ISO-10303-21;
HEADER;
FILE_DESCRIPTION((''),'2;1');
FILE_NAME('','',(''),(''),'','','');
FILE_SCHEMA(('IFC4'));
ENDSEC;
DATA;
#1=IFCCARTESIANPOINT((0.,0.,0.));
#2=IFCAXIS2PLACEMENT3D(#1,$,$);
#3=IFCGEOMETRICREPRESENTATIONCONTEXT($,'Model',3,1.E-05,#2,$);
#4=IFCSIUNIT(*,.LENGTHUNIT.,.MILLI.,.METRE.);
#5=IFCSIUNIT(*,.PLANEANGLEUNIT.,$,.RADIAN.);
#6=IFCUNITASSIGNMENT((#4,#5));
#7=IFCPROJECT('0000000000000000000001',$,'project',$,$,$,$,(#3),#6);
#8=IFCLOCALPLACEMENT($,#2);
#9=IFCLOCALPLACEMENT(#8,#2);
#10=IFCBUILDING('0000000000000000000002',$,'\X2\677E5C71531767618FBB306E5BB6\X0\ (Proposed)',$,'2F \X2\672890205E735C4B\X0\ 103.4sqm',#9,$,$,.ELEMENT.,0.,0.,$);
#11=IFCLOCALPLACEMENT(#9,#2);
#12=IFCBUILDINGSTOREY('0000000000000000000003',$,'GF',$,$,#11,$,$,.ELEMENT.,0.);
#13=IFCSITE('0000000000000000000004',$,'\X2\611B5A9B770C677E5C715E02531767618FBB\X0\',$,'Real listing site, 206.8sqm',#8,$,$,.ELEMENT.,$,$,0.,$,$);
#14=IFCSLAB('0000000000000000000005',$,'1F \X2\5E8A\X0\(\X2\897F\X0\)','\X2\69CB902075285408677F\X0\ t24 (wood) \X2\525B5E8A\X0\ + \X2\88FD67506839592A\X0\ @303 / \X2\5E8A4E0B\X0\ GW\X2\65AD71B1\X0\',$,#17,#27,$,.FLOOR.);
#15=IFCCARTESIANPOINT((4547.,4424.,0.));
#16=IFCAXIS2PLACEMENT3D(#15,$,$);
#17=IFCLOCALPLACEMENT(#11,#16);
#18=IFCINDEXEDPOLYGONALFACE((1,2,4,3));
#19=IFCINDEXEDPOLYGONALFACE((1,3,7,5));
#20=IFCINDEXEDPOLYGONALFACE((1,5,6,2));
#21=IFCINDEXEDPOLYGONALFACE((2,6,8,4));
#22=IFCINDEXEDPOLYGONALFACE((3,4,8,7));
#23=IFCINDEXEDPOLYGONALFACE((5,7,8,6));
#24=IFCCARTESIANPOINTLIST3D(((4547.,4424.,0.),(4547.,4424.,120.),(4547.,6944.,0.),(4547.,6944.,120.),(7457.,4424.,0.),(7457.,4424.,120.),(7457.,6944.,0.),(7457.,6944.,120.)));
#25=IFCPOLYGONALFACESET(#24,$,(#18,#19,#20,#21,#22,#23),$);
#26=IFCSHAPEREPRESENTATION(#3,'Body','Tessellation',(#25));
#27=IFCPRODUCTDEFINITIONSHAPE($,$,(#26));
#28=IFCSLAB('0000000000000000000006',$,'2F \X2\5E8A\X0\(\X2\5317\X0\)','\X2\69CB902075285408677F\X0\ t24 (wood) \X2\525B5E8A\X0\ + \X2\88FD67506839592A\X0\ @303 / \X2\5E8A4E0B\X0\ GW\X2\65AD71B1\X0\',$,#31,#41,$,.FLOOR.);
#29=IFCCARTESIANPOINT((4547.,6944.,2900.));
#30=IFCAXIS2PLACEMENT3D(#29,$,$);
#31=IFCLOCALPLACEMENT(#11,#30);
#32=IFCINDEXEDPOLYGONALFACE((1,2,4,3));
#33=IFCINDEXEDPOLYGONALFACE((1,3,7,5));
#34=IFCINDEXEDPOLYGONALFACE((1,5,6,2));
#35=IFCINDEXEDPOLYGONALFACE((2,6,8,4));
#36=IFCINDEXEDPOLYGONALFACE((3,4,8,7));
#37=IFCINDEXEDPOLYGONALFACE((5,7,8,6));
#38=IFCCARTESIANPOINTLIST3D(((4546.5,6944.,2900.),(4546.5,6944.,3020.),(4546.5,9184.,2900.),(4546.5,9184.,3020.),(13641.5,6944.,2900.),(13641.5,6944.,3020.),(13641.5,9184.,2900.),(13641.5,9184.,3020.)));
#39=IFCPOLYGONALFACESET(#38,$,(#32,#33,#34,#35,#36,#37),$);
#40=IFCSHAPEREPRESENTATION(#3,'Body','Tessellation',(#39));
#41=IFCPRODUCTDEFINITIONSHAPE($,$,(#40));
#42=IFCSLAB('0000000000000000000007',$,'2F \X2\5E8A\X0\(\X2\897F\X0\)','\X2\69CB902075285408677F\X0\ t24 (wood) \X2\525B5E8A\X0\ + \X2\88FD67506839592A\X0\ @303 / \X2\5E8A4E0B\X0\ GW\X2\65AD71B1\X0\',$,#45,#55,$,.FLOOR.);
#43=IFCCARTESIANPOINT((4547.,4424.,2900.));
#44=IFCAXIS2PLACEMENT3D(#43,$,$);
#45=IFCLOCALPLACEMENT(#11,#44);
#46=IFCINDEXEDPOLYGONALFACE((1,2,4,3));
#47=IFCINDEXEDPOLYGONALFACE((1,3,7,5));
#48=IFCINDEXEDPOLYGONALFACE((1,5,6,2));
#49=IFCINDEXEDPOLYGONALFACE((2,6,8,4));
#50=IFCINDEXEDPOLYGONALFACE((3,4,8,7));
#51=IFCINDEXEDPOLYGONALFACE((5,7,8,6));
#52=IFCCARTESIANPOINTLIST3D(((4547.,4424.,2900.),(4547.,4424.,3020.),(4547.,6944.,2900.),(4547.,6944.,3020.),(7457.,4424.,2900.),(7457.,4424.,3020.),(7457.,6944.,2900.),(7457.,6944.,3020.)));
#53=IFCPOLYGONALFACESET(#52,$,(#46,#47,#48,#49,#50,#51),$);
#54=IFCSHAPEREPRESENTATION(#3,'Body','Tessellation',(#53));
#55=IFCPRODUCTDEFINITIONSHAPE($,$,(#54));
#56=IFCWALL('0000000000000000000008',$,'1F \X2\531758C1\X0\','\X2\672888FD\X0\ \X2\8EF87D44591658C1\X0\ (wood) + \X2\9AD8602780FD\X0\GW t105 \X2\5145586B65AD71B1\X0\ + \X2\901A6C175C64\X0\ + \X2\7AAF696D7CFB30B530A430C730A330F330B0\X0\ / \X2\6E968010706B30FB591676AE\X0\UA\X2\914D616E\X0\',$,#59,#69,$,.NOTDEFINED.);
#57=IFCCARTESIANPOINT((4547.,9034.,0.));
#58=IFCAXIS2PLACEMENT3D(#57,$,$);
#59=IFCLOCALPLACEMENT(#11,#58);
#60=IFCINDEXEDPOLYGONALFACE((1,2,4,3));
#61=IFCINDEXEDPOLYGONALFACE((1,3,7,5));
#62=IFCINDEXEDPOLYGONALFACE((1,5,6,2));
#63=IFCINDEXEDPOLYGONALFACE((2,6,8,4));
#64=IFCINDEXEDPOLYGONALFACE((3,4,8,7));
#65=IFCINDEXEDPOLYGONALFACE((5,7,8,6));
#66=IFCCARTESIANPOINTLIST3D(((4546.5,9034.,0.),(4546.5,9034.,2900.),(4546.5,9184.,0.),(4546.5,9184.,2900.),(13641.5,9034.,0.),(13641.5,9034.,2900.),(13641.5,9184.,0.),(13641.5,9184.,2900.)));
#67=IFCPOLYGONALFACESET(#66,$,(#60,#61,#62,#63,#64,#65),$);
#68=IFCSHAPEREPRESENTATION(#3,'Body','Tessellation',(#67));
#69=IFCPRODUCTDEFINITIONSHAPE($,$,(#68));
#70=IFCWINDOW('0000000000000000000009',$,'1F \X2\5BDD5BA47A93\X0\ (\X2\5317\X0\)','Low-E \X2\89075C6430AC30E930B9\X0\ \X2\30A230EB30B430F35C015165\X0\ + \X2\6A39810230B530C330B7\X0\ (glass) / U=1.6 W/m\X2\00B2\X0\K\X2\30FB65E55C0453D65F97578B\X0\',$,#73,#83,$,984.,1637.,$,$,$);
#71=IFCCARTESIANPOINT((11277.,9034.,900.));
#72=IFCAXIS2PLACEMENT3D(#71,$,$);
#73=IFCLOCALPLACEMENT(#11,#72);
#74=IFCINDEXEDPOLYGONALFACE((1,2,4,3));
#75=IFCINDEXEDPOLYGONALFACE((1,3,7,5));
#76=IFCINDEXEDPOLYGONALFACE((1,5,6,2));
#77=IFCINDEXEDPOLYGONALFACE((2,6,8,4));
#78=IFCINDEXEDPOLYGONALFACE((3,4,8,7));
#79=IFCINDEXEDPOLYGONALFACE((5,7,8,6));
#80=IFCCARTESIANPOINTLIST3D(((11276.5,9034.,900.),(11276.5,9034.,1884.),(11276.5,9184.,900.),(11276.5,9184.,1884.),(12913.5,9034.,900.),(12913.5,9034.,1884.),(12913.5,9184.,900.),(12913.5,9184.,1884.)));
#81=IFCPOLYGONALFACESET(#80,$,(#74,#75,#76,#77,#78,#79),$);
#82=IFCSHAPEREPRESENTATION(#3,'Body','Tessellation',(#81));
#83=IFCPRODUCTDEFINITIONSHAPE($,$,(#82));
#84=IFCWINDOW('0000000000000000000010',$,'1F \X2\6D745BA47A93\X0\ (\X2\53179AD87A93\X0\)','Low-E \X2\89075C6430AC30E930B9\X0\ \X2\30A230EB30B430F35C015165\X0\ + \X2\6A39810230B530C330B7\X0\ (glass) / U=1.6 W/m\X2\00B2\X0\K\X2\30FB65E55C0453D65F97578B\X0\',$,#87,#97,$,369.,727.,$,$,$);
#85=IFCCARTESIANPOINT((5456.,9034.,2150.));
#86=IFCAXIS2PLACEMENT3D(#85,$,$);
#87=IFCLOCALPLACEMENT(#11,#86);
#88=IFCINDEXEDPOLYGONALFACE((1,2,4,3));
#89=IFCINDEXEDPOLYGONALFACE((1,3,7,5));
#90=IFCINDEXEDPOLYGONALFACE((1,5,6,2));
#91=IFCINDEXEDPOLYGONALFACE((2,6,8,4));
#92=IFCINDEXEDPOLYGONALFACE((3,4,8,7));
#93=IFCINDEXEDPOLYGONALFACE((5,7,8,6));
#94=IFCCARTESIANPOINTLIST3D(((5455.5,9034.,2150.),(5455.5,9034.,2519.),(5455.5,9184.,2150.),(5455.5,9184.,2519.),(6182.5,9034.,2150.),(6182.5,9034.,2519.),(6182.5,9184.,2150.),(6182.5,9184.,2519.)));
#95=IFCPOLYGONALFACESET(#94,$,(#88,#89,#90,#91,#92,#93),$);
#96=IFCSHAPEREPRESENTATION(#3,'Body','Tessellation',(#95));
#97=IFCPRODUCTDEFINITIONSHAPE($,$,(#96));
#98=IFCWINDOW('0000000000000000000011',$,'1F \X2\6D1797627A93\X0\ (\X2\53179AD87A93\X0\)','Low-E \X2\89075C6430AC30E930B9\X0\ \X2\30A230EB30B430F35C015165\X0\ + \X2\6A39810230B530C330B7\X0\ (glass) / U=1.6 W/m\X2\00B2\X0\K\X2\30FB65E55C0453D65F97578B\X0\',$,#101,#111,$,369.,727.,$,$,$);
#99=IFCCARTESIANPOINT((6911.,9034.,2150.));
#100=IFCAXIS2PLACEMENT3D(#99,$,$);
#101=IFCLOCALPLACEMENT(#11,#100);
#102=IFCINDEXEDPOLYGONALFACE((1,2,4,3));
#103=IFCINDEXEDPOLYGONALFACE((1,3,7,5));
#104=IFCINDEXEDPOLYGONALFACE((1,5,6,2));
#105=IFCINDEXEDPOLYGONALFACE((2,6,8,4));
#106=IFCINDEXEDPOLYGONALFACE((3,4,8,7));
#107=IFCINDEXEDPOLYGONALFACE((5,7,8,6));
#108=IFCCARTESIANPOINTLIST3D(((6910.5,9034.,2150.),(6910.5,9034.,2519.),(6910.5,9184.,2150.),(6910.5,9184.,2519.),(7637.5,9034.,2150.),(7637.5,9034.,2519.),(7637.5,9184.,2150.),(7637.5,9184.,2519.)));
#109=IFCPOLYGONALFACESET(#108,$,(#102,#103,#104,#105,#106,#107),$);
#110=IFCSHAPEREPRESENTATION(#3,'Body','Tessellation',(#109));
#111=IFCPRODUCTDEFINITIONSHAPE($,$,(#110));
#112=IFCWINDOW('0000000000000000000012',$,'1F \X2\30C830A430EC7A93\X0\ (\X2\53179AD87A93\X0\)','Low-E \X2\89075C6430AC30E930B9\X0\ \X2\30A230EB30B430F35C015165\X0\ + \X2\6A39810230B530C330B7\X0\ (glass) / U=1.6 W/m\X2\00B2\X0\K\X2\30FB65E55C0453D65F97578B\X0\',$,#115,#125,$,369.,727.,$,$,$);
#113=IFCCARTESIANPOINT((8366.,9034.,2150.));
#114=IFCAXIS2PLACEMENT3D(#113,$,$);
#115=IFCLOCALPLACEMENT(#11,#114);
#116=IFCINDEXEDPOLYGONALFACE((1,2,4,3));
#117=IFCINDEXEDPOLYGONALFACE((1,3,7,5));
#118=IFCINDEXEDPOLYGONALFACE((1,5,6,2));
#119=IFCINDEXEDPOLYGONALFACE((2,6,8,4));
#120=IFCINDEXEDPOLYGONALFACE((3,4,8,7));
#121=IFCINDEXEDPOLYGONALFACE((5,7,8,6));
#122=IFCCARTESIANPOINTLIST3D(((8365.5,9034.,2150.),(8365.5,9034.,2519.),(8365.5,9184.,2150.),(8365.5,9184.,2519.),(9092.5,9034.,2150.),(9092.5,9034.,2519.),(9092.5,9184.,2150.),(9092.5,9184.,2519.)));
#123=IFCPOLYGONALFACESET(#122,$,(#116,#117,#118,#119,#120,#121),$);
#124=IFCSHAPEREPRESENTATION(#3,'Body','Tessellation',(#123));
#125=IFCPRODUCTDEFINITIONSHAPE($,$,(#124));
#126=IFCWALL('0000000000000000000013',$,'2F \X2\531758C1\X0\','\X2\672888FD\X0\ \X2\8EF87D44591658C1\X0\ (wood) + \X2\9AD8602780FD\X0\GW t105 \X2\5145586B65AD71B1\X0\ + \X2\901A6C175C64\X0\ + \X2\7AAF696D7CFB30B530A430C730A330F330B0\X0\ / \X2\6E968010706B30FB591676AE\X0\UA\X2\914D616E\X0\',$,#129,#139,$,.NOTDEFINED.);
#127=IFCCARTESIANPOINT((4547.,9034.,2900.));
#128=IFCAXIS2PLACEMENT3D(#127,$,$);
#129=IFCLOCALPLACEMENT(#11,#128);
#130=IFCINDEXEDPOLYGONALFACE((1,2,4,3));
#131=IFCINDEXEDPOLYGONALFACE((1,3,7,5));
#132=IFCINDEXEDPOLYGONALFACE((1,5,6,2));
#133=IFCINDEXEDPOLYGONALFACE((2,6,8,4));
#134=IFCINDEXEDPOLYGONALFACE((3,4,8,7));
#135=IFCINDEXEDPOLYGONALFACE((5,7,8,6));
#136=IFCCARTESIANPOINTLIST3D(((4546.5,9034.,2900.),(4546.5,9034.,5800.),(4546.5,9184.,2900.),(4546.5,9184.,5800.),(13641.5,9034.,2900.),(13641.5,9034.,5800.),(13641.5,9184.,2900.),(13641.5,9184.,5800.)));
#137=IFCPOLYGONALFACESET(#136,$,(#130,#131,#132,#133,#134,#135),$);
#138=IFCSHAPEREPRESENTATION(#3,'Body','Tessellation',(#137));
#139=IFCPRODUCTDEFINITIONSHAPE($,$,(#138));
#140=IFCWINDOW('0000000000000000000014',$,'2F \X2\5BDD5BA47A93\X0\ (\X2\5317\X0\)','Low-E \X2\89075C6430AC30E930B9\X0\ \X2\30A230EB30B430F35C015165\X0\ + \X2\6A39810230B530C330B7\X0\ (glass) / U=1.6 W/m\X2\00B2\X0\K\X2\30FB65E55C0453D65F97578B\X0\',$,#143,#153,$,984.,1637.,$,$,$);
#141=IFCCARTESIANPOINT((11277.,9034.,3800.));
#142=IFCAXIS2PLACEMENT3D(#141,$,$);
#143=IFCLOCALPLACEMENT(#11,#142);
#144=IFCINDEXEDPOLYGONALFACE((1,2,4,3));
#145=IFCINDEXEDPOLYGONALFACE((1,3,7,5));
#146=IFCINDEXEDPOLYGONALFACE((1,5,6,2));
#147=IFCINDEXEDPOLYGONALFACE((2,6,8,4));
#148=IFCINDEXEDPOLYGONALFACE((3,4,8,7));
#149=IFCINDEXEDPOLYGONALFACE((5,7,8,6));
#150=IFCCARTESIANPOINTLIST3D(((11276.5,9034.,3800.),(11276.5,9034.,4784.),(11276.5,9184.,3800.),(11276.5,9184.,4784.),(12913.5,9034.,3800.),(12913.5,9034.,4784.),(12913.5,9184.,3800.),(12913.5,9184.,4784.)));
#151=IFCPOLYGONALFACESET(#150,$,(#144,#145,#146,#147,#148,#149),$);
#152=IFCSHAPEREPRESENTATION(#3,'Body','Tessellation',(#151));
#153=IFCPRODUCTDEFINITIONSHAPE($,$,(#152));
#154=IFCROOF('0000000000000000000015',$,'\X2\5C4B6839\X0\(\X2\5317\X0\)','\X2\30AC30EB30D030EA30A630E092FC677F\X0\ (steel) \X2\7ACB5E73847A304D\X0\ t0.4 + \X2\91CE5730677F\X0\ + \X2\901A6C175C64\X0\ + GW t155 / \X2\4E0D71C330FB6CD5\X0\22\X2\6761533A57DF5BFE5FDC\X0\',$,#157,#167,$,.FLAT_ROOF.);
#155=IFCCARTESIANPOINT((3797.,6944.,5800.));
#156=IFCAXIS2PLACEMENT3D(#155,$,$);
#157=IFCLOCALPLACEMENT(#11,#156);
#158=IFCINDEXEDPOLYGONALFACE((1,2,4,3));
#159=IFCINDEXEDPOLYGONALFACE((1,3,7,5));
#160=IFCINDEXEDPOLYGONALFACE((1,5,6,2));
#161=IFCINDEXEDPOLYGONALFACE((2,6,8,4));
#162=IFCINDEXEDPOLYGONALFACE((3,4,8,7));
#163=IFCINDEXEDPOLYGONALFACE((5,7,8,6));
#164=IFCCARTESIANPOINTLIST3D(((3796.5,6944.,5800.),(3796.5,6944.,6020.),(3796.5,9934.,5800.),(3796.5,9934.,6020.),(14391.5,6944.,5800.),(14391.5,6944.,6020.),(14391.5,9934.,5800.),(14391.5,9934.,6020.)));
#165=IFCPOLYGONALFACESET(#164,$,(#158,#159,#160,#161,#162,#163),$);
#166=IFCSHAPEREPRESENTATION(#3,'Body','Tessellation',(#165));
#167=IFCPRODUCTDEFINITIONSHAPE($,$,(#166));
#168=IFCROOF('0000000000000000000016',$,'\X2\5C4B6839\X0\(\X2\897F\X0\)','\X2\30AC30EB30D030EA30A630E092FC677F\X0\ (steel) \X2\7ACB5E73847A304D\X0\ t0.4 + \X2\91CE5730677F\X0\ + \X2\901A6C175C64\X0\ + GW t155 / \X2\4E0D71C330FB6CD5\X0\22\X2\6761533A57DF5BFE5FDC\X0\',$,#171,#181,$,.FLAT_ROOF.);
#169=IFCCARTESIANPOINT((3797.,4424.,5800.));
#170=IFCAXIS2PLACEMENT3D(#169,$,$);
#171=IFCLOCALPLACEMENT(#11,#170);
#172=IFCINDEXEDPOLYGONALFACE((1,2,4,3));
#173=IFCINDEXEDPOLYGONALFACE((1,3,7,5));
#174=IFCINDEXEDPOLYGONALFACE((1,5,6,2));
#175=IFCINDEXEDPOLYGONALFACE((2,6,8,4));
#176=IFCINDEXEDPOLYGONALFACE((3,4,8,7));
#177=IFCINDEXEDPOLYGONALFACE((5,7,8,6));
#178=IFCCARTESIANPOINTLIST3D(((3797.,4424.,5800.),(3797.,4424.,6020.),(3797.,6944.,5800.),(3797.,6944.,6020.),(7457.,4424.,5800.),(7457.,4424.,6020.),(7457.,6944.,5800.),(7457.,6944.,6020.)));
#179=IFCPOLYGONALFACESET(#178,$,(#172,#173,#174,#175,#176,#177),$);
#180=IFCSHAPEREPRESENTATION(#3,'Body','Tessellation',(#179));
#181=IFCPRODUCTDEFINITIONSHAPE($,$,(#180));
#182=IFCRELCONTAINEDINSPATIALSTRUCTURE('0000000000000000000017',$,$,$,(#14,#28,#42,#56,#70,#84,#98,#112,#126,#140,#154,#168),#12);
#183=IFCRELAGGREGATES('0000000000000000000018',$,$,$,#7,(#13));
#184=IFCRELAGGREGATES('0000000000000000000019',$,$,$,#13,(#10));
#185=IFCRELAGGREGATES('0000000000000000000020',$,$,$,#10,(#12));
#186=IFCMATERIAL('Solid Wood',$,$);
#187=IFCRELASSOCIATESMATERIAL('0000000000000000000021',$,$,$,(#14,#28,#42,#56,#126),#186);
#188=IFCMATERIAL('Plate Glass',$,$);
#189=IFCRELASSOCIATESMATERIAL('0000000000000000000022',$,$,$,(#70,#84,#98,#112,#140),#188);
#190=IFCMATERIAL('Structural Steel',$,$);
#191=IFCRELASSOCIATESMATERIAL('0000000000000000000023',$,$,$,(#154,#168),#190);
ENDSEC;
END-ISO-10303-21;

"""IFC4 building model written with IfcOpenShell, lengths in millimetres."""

from ifc_helpers import new_model, si_unit, frame, frame_2d, origin, place, context, project, spatial, rectangle, extrude, material, element, fill, save


model = new_model("IFC4")

# Units and contexts
model_context = context("Model", 3, precision=1e-05, world=origin())
ifc_project = project(units=[si_unit("LENGTHUNIT", "METRE", prefix="MILLI"), si_unit("PLANEANGLEUNIT", "RADIAN")], contexts=[model_context])

# Site, building, storey
site_placement = place(None, origin())
site = spatial("IfcSite", under=ifc_project, at=site_placement, Name="愛媛県松山市北条辻", ObjectType="Real listing site, 206.8sqm", CompositionType="ELEMENT", RefElevation=0.0)
building_placement = place(site_placement, origin())
building = spatial("IfcBuilding", under=site, at=building_placement, Name="松山北条辻の家 (Proposed)", ObjectType="2F 木造平屋 103.4sqm", CompositionType="ELEMENT", ElevationOfRefHeight=0.0, ElevationOfTerrain=0.0)
storey_placement = place(building_placement, origin())
storey = spatial("IfcBuildingStorey", under=building, at=storey_placement, Name="GF", CompositionType="ELEMENT", Elevation=0.0)

# Slabs
ifc_material_1 = material(Name="Solid Wood")
slab_1_placement = place(storey_placement, frame((4547.0, 4424.0, 0.0)))
element("IfcSlab", 1, at=slab_1_placement, inside=storey, material=ifc_material_1, Name="1F 床(西)", Description="構造用合板 t24 (wood) 剛床 + 製材根太 @303 / 床下 GW断熱", PredefinedType="FLOOR", context=model_context, shape_type="SweptSolid", body=[
    extrude(rectangle(XDim=2910.0, YDim=2520.0, at=frame_2d((1455.0, 1260.0))), frame((4547.0, 4424.0, 0.0)), (0.0, 0.0, 1.0), 120.0),
])
slab_2_placement = place(storey_placement, frame((4547.0, 6944.0, 2900.0)))
element("IfcSlab", 2, at=slab_2_placement, inside=storey, material=ifc_material_1, Name="2F 床(北)", Description="構造用合板 t24 (wood) 剛床 + 製材根太 @303 / 床下 GW断熱", PredefinedType="FLOOR", context=model_context, shape_type="SweptSolid", body=[
    extrude(rectangle(XDim=9095.0, YDim=2240.0, at=frame_2d((4547.0, 1120.0))), frame((4547.0, 6944.0, 2900.0)), (0.0, 0.0, 1.0), 120.0),
])
slab_3_placement = place(storey_placement, frame((4547.0, 4424.0, 2900.0)))
element("IfcSlab", 3, at=slab_3_placement, inside=storey, material=ifc_material_1, Name="2F 床(西)", Description="構造用合板 t24 (wood) 剛床 + 製材根太 @303 / 床下 GW断熱", PredefinedType="FLOOR", context=model_context, shape_type="SweptSolid", body=[
    extrude(rectangle(XDim=2910.0, YDim=2520.0, at=frame_2d((1455.0, 1260.0))), frame((4547.0, 4424.0, 2900.0)), (0.0, 0.0, 1.0), 120.0),
])

# Wall, openings, windows
wall_1_placement = place(storey_placement, frame((4547.0, 9034.0, 0.0)))
wall_1 = element("IfcWall", 4, at=wall_1_placement, inside=storey, material=ifc_material_1, Name="1F 北壁", Description="木製 軸組外壁 (wood) + 高性能GW t105 充填断熱 + 通気層 + 窯業系サイディング / 準耐火・外皮UA配慮", PredefinedType="NOTDEFINED", context=model_context, shape_type="SweptSolid", body=[
    extrude(rectangle(XDim=9095.0, YDim=150.0, at=frame_2d((4547.0, 75.0))), frame((4547.0, 9034.0, 0.0)), (0.0, 0.0, 1.0), 2900.0),
])
opening_1_placement = place(storey_placement, frame((11277.0, 9034.0, 900.0)))
opening_1 = element("IfcOpeningElement", 5, at=opening_1_placement, cuts=wall_1, PredefinedType="NOTDEFINED", context=model_context, shape_type="SweptSolid", body=[
    extrude(rectangle(XDim=1637.0, YDim=150.0, at=frame_2d((818.0, 75.0))), frame((11277.0, 9034.0, 900.0)), (0.0, 0.0, 1.0), 984.0),
])
opening_2_placement = place(storey_placement, frame((5456.0, 9034.0, 2150.0)))
opening_2 = element("IfcOpeningElement", 6, at=opening_2_placement, cuts=wall_1, PredefinedType="NOTDEFINED", context=model_context, shape_type="SweptSolid", body=[
    extrude(rectangle(XDim=727.0, YDim=150.0, at=frame_2d((363.0, 75.0))), frame((5456.0, 9034.0, 2150.0)), (0.0, 0.0, 1.0), 369.0),
])
opening_3_placement = place(storey_placement, frame((6911.0, 9034.0, 2150.0)))
opening_3 = element("IfcOpeningElement", 7, at=opening_3_placement, cuts=wall_1, PredefinedType="NOTDEFINED", context=model_context, shape_type="SweptSolid", body=[
    extrude(rectangle(XDim=727.0, YDim=150.0, at=frame_2d((363.0, 75.0))), frame((6911.0, 9034.0, 2150.0)), (0.0, 0.0, 1.0), 369.0),
])
opening_4_placement = place(storey_placement, frame((8366.0, 9034.0, 2150.0)))
opening_4 = element("IfcOpeningElement", 8, at=opening_4_placement, cuts=wall_1, PredefinedType="NOTDEFINED", context=model_context, shape_type="SweptSolid", body=[
    extrude(rectangle(XDim=727.0, YDim=150.0, at=frame_2d((363.0, 75.0))), frame((8366.0, 9034.0, 2150.0)), (0.0, 0.0, 1.0), 369.0),
])
ifc_material_2 = material(Name="Plate Glass")
window_1_placement = place(storey_placement, frame((11277.0, 9034.0, 900.0)))
window_1 = element("IfcWindow", 9, at=window_1_placement, inside=storey, material=ifc_material_2, Name="1F 寝室窓 (北)", Description="Low-E 複層ガラス アルゴン封入 + 樹脂サッシ (glass) / U=1.6 W/m²K・日射取得型", OverallHeight=984.0, OverallWidth=1637.0, context=model_context, shape_type="SweptSolid", body=[
    extrude(rectangle(XDim=1637.0, YDim=150.0, at=frame_2d((818.0, 75.0))), frame((11277.0, 9034.0, 900.0)), (0.0, 0.0, 1.0), 984.0),
])
fill(opening_1, window_1)
window_2_placement = place(storey_placement, frame((5456.0, 9034.0, 2150.0)))
window_2 = element("IfcWindow", 10, at=window_2_placement, inside=storey, material=ifc_material_2, Name="1F 浴室窓 (北高窓)", Description="Low-E 複層ガラス アルゴン封入 + 樹脂サッシ (glass) / U=1.6 W/m²K・日射取得型", OverallHeight=369.0, OverallWidth=727.0, context=model_context, shape_type="SweptSolid", body=[
    extrude(rectangle(XDim=727.0, YDim=150.0, at=frame_2d((363.0, 75.0))), frame((5456.0, 9034.0, 2150.0)), (0.0, 0.0, 1.0), 369.0),
])
fill(opening_2, window_2)
window_3_placement = place(storey_placement, frame((6911.0, 9034.0, 2150.0)))
window_3 = element("IfcWindow", 11, at=window_3_placement, inside=storey, material=ifc_material_2, Name="1F 洗面窓 (北高窓)", Description="Low-E 複層ガラス アルゴン封入 + 樹脂サッシ (glass) / U=1.6 W/m²K・日射取得型", OverallHeight=369.0, OverallWidth=727.0, context=model_context, shape_type="SweptSolid", body=[
    extrude(rectangle(XDim=727.0, YDim=150.0, at=frame_2d((363.0, 75.0))), frame((6911.0, 9034.0, 2150.0)), (0.0, 0.0, 1.0), 369.0),
])
fill(opening_3, window_3)
window_4_placement = place(storey_placement, frame((8366.0, 9034.0, 2150.0)))
window_4 = element("IfcWindow", 12, at=window_4_placement, inside=storey, material=ifc_material_2, Name="1F トイレ窓 (北高窓)", Description="Low-E 複層ガラス アルゴン封入 + 樹脂サッシ (glass) / U=1.6 W/m²K・日射取得型", OverallHeight=369.0, OverallWidth=727.0, context=model_context, shape_type="SweptSolid", body=[
    extrude(rectangle(XDim=727.0, YDim=150.0, at=frame_2d((363.0, 75.0))), frame((8366.0, 9034.0, 2150.0)), (0.0, 0.0, 1.0), 369.0),
])
fill(opening_4, window_4)

# Wall, opening, window
wall_2_placement = place(storey_placement, frame((4547.0, 9034.0, 2900.0)))
wall_2 = element("IfcWall", 13, at=wall_2_placement, inside=storey, material=ifc_material_1, Name="2F 北壁", Description="木製 軸組外壁 (wood) + 高性能GW t105 充填断熱 + 通気層 + 窯業系サイディング / 準耐火・外皮UA配慮", PredefinedType="NOTDEFINED", context=model_context, shape_type="SweptSolid", body=[
    extrude(rectangle(XDim=9095.0, YDim=150.0, at=frame_2d((4547.0, 75.0))), frame((4547.0, 9034.0, 2900.0)), (0.0, 0.0, 1.0), 2900.0),
])
opening_5_placement = place(storey_placement, frame((11277.0, 9034.0, 3800.0)))
opening_5 = element("IfcOpeningElement", 14, at=opening_5_placement, cuts=wall_2, PredefinedType="NOTDEFINED", context=model_context, shape_type="SweptSolid", body=[
    extrude(rectangle(XDim=1637.0, YDim=150.0, at=frame_2d((818.0, 75.0))), frame((11277.0, 9034.0, 3800.0)), (0.0, 0.0, 1.0), 984.0),
])
window_5_placement = place(storey_placement, frame((11277.0, 9034.0, 3800.0)))
window_5 = element("IfcWindow", 15, at=window_5_placement, inside=storey, material=ifc_material_2, Name="2F 寝室窓 (北)", Description="Low-E 複層ガラス アルゴン封入 + 樹脂サッシ (glass) / U=1.6 W/m²K・日射取得型", OverallHeight=984.0, OverallWidth=1637.0, context=model_context, shape_type="SweptSolid", body=[
    extrude(rectangle(XDim=1637.0, YDim=150.0, at=frame_2d((818.0, 75.0))), frame((11277.0, 9034.0, 3800.0)), (0.0, 0.0, 1.0), 984.0),
])
fill(opening_5, window_5)

# Roofs
ifc_material_3 = material(Name="Structural Steel")
for number, where, name in (
    (16, (3797.0, 6944.0, 5800.0), "屋根(北)"),
):
    element("IfcRoof", number, at=place(storey_placement, frame(where)), inside=storey, material=ifc_material_3, Name=name, Description="ガルバリウム鋼板 (steel) 立平葺き t0.4 + 野地板 + 通気層 + GW t155 / 不燃・法22条区域対応", PredefinedType="FLAT_ROOF", context=model_context, shape_type="SweptSolid", body=[
        extrude(rectangle(XDim=10595.0, YDim=2990.0, at=frame_2d((5297.0, 1495.0))), frame((3797.0, 6944.0, 5800.0)), (0.0, 0.0, 1.0), 220.0),
    ])
roof_placement = place(storey_placement, frame((3797.0, 4424.0, 5800.0)))
element("IfcRoof", 17, at=roof_placement, inside=storey, material=ifc_material_3, Name="屋根(西)", Description="ガルバリウム鋼板 (steel) 立平葺き t0.4 + 野地板 + 通気層 + GW t155 / 不燃・法22条区域対応", PredefinedType="FLAT_ROOF", context=model_context, shape_type="SweptSolid", body=[
    extrude(rectangle(XDim=3660.0, YDim=2520.0, at=frame_2d((1830.0, 1260.0))), frame((3797.0, 4424.0, 5800.0)), (0.0, 0.0, 1.0), 220.0),
])

save(model, "model.ifc")
